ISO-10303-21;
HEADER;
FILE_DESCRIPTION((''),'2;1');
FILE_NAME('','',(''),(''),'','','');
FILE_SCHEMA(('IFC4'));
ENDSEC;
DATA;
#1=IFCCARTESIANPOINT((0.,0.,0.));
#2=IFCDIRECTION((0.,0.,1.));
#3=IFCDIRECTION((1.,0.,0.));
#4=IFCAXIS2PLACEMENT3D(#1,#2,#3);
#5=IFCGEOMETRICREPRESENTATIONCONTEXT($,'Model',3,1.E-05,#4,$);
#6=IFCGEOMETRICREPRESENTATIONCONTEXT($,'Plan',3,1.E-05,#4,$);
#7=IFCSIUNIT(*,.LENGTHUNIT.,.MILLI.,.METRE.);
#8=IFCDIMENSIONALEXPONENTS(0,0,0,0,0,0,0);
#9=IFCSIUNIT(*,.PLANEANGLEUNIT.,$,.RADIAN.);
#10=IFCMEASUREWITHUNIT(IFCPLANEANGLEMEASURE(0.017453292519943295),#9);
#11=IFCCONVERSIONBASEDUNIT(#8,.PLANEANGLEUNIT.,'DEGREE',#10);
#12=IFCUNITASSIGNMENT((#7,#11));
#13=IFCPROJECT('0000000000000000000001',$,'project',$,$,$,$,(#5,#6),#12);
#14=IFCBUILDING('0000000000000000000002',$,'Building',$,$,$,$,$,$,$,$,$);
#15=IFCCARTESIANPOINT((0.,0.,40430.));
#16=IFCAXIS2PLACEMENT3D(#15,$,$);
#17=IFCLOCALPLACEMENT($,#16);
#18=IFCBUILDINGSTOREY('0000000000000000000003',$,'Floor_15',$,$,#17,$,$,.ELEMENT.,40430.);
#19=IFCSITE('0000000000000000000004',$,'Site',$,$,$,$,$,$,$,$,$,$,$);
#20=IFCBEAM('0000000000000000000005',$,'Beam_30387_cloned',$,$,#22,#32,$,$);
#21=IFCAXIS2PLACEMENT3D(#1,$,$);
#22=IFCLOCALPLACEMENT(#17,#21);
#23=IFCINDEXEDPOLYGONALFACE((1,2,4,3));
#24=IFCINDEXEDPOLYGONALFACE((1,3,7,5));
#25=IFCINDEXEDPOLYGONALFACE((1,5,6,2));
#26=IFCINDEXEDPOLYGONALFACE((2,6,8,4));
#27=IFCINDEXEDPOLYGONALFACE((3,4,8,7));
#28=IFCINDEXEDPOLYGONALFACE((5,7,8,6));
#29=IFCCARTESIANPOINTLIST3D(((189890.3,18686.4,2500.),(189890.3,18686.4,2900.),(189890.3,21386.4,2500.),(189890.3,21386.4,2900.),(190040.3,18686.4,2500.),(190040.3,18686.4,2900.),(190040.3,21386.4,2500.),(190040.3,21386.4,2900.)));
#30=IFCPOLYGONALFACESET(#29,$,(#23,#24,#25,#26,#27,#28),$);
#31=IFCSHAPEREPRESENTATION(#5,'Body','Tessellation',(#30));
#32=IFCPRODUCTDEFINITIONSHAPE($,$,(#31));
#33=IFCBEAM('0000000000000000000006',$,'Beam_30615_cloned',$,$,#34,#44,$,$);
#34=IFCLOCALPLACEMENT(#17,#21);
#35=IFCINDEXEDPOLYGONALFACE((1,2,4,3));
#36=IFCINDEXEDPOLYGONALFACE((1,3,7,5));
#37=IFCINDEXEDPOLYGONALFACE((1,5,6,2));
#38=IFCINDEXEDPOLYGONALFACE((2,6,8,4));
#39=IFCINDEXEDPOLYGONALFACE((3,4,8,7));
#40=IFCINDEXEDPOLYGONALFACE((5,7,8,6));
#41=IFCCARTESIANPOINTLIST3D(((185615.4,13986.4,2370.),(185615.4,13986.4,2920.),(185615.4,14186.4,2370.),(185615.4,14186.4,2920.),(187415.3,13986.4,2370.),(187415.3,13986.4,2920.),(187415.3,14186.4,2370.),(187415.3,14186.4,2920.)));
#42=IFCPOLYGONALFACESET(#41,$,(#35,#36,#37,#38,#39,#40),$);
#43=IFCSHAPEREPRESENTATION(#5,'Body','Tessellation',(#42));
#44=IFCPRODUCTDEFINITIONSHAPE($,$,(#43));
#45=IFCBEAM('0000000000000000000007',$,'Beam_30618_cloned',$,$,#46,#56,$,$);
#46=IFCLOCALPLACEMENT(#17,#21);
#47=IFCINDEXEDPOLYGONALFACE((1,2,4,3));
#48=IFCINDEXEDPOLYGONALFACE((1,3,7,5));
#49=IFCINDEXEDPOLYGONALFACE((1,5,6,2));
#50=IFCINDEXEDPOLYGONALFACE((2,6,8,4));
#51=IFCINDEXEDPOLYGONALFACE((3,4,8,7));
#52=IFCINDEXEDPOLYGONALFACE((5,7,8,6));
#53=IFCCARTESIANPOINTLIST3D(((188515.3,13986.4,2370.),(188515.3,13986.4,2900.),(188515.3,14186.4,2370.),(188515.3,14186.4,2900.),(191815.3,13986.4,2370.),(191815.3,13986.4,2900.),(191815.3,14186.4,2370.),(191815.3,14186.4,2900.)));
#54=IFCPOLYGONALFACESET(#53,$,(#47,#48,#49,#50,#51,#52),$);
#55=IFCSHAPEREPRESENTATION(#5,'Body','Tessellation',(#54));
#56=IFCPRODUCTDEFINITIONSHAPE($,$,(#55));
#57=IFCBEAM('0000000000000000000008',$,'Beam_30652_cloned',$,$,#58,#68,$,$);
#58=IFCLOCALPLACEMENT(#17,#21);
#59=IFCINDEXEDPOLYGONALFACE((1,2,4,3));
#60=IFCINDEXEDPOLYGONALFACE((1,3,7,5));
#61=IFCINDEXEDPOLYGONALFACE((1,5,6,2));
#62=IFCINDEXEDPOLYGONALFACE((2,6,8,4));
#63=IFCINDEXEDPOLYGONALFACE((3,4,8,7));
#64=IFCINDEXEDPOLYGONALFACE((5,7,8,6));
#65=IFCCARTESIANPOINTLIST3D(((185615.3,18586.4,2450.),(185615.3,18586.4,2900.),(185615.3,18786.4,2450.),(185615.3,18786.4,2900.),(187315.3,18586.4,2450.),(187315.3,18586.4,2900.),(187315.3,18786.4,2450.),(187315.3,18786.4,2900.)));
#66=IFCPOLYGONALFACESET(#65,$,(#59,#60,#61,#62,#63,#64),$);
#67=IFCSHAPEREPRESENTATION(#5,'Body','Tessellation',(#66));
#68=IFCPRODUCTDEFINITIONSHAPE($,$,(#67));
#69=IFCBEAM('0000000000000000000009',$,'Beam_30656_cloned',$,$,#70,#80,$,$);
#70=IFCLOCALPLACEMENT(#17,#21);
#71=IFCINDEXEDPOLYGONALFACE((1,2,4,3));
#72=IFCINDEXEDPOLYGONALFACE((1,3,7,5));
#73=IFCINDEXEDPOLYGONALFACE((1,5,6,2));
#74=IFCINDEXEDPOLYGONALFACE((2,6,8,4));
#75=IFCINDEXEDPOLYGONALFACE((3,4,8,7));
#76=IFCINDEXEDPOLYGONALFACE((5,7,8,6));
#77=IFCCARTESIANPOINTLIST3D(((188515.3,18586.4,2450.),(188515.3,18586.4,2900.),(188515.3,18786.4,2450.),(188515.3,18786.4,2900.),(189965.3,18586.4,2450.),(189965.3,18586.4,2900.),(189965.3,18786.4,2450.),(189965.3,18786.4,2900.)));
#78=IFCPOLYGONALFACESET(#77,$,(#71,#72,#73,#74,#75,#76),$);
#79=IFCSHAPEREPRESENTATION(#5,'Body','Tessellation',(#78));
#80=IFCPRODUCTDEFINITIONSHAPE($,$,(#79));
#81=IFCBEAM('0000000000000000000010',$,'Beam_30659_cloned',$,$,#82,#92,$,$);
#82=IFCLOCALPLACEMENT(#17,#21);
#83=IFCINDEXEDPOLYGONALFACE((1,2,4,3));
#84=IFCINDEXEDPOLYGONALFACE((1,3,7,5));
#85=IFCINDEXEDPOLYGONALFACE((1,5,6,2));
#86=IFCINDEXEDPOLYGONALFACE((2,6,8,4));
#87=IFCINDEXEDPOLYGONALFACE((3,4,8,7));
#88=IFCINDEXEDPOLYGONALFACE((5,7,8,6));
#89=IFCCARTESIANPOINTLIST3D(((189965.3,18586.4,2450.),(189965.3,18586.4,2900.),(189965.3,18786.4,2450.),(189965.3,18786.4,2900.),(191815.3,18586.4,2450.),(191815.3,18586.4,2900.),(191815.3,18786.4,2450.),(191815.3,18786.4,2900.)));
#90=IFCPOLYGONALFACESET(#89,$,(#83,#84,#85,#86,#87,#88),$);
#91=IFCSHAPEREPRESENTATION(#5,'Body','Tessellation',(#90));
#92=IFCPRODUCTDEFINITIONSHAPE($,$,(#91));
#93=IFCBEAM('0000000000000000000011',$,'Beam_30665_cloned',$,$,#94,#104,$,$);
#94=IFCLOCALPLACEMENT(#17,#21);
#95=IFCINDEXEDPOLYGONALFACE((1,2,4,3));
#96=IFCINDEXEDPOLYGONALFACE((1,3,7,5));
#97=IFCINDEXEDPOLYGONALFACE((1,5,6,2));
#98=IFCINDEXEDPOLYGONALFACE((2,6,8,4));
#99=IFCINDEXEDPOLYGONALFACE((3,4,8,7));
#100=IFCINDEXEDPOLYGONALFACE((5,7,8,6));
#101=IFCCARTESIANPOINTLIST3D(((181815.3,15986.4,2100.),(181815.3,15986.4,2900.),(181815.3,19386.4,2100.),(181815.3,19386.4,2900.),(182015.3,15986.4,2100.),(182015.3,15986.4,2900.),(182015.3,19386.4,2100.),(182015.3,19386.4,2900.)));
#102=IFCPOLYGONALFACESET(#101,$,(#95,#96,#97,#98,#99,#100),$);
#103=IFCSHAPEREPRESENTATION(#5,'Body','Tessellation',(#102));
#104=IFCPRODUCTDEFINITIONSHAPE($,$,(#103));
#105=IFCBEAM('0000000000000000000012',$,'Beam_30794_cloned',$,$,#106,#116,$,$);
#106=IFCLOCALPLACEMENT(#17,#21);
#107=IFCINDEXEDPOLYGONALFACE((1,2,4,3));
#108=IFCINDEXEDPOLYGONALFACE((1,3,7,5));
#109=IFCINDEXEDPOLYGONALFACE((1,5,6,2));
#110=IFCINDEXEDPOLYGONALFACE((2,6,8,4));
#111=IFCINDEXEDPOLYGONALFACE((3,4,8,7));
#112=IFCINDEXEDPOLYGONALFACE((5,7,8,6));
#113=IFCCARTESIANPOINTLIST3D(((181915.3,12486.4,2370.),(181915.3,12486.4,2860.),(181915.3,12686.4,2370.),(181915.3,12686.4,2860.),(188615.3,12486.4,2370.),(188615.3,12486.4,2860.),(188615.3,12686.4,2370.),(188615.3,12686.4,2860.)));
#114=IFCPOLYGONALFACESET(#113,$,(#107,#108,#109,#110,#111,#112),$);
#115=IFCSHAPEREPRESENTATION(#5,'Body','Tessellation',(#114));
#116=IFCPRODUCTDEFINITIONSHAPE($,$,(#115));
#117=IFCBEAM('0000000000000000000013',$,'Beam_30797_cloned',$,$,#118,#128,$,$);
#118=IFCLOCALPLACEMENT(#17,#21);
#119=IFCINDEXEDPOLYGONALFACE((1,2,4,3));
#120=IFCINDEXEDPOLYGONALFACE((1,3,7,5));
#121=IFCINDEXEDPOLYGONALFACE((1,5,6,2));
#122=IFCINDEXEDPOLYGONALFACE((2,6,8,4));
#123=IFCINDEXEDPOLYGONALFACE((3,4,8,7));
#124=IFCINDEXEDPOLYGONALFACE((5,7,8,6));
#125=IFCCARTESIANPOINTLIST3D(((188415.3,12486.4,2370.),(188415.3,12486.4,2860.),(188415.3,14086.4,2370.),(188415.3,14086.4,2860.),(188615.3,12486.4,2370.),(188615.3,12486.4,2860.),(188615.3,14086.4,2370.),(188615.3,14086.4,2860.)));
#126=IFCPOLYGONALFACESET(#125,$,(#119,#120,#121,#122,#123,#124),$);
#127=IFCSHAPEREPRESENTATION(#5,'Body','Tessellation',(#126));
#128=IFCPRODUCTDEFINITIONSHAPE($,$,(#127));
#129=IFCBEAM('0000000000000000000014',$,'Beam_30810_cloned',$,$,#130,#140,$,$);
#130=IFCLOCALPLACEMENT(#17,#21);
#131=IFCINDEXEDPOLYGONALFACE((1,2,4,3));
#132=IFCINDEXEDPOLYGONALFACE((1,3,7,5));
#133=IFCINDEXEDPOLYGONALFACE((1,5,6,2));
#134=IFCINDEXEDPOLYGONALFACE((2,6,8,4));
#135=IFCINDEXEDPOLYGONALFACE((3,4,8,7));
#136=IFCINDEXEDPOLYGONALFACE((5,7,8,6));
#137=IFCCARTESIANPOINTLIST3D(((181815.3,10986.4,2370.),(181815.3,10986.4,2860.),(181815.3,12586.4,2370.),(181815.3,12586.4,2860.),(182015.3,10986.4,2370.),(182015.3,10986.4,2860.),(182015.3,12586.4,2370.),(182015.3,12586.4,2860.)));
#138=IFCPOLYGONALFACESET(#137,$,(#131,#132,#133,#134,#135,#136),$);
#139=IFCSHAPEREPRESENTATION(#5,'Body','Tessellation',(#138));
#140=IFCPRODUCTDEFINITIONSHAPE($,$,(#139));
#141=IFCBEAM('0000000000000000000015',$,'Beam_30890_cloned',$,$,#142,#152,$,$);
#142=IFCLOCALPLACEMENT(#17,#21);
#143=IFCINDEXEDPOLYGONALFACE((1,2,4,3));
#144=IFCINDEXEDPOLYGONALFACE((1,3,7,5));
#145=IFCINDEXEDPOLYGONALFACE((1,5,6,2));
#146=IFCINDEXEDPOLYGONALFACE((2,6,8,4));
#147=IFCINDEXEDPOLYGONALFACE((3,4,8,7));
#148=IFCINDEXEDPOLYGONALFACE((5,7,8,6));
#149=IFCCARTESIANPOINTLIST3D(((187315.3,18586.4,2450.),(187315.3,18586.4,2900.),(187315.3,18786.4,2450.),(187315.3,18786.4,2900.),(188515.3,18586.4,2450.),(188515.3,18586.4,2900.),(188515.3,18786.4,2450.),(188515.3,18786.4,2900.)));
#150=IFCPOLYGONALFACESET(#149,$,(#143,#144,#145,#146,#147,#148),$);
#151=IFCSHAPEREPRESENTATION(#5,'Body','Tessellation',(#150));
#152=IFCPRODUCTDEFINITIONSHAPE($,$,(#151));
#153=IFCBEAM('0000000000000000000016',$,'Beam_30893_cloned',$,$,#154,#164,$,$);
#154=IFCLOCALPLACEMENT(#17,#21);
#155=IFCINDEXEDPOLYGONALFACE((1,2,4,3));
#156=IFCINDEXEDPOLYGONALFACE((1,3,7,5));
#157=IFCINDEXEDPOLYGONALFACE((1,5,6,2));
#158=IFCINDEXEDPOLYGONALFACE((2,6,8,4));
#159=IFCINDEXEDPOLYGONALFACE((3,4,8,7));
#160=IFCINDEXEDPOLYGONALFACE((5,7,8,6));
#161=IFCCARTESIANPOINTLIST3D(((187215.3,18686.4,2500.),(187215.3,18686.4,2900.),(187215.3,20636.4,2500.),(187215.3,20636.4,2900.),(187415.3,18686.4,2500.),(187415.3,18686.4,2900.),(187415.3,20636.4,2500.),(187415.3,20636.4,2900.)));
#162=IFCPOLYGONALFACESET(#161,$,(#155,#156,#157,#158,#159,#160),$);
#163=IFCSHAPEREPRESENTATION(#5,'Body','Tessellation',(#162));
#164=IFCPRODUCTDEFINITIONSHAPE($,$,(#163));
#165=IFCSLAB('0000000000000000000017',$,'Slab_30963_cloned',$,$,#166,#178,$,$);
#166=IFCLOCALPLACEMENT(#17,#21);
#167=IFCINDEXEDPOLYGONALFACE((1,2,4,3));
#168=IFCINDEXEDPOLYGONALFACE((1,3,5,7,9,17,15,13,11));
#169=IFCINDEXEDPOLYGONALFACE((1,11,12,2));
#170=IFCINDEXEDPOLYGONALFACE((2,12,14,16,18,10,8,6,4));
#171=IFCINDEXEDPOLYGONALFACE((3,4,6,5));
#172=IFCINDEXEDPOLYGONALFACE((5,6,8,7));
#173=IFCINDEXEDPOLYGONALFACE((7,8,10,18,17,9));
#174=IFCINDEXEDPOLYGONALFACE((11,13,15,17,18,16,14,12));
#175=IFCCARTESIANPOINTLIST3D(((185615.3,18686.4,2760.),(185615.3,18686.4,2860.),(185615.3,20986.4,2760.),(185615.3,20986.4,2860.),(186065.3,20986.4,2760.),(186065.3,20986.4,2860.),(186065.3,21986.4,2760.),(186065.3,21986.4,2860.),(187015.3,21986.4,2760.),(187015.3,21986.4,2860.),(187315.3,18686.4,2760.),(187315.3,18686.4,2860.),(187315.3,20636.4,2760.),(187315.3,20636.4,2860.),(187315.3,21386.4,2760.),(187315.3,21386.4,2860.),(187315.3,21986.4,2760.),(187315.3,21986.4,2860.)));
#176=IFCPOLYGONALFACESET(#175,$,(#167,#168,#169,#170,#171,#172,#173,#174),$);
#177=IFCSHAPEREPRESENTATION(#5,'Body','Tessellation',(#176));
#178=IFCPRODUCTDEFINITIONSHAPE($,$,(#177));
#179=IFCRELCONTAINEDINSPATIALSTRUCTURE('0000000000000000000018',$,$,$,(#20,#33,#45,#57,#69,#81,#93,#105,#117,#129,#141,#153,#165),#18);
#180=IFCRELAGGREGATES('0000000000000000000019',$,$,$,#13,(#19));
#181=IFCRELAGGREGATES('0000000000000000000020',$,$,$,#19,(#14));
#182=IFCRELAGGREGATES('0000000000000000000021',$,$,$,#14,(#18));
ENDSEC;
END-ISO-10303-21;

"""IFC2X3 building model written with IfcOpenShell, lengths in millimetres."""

from ifc_helpers import new_model, entity, si_unit, converted_unit, frame, origin_with_axes, origin_2d, place, context, project, spatial, polyline, rectangle, outline, extrude, source, transform, mapped, element, save


model = new_model("IFC2X3")

# Units and contexts
model_context = context("Model", 3, precision=1e-05, world=origin_with_axes())
plan_context = context("Plan", 3, precision=1e-05, world=origin_with_axes())
ifc_project = project(units=[si_unit("LENGTHUNIT", "METRE", prefix="MILLI"), converted_unit("PLANEANGLEUNIT", "DEGREE", entity("IfcPlaneAngleMeasure", 0.017453292519943295), si_unit("PLANEANGLEUNIT", "RADIAN"), dimensions=[0, 0, 0, 0, 0, 0, 0])], contexts=[model_context, plan_context])

# Site, building, storey
site = spatial("IfcSite", under=ifc_project, Name="Site")
building = spatial("IfcBuilding", under=site, Name="Building")
storey_placement = place(None, frame((0.0, 0.0, 40430.0)))
storey = spatial("IfcBuildingStorey", under=building, at=storey_placement, Name="Floor_15", CompositionType="ELEMENT", Elevation=40430.0)

# Beams
shared_shape_1 = source(origin_with_axes(), model_context, "Body", "SweptSolid", [
    extrude(rectangle(XDim=150.0, YDim=400.0, at=origin_2d()), origin_with_axes(), (0.0, 0.0, 1.0), 2700.0),
])
beam_1_placement = place(storey_placement, frame((189965.3, 18686.4, 2700.0), z_axis=(0.0, 2700.0, 0.0), x_axis=(2700.0, 0.0, 0.0)))
element("IfcBeam", 1, at=beam_1_placement, inside=storey, Name="Beam_30387_cloned", context=model_context, shape_type="MappedRepresentation", body=[
    mapped(shared_shape_1, transform((0.0, 0.0, 0.0), x_axis=(1.0, 0.0, 0.0), y_axis=(0.0, 1.0, 0.0), z_axis=(0.0, 0.0, 1.0), scale=1.0)),
])
shared_shape_2 = source(origin_with_axes(), model_context, "Body", "SweptSolid", [
    extrude(rectangle(XDim=200.0, YDim=550.0, at=origin_2d()), origin_with_axes(), (0.0, 0.0, 1.0), 1799.9),
])
beam_2_placement = place(storey_placement, frame((185615.4, 14086.4, 2645.0), z_axis=(1799.945586, 0.0, 0.0), x_axis=(0.0, -1799.945586, 0.0)))
element("IfcBeam", 2, at=beam_2_placement, inside=storey, Name="Beam_30615_cloned", context=model_context, shape_type="MappedRepresentation", body=[
    mapped(shared_shape_2, transform((0.0, 0.0, 0.0), x_axis=(1.0, 0.0, 0.0), y_axis=(0.0, 1.0, 0.0), z_axis=(0.0, 0.0, 1.0), scale=1.0)),
])
shared_shape_3 = source(origin_with_axes(), model_context, "Body", "SweptSolid", [
    extrude(rectangle(XDim=200.0, YDim=530.0, at=origin_2d()), origin_with_axes(), (0.0, 0.0, 1.0), 3300.0),
])
beam_3_placement = place(storey_placement, frame((188515.3, 14086.4, 2635.0), z_axis=(3299.979202, 0.0, 0.0), x_axis=(0.0, -3299.979202, 0.0)))
element("IfcBeam", 3, at=beam_3_placement, inside=storey, Name="Beam_30618_cloned", context=model_context, shape_type="MappedRepresentation", body=[
    mapped(shared_shape_3, transform((0.0, 0.0, 0.0), x_axis=(1.0, 0.0, 0.0), y_axis=(0.0, 1.0, 0.0), z_axis=(0.0, 0.0, 1.0), scale=1.0)),
])
shared_shape_4 = source(origin_with_axes(), model_context, "Body", "SweptSolid", [
    extrude(rectangle(XDim=200.0, YDim=450.0, at=origin_2d()), origin_with_axes(), (0.0, 0.0, 1.0), 1700.0),
])
beam_4_placement = place(storey_placement, frame((185615.3, 18686.4, 2675.0), z_axis=(1700.0, 0.0, 0.0), x_axis=(0.0, -1700.0, 0.0)))
element("IfcBeam", 4, at=beam_4_placement, inside=storey, Name="Beam_30652_cloned", context=model_context, shape_type="MappedRepresentation", body=[
    mapped(shared_shape_4, transform((0.0, 0.0, 0.0), x_axis=(1.0, 0.0, 0.0), y_axis=(0.0, 1.0, 0.0), z_axis=(0.0, 0.0, 1.0), scale=1.0)),
])
shared_shape_5 = source(origin_with_axes(), model_context, "Body", "SweptSolid", [
    extrude(rectangle(XDim=200.0, YDim=450.0, at=origin_2d()), origin_with_axes(), (0.0, 0.0, 1.0), 1450.0),
])
beam_5_placement = place(storey_placement, frame((188515.3, 18686.4, 2675.0), z_axis=(1449.979201, 0.0, 0.0), x_axis=(0.0, -1449.979201, 0.0)))
element("IfcBeam", 5, at=beam_5_placement, inside=storey, Name="Beam_30656_cloned", context=model_context, shape_type="MappedRepresentation", body=[
    mapped(shared_shape_5, transform((0.0, 0.0, 0.0), x_axis=(1.0, 0.0, 0.0), y_axis=(0.0, 1.0, 0.0), z_axis=(0.0, 0.0, 1.0), scale=1.0)),
])
shared_shape_6 = source(origin_with_axes(), model_context, "Body", "SweptSolid", [
    extrude(rectangle(XDim=200.0, YDim=450.0, at=origin_2d()), origin_with_axes(), (0.0, 0.0, 1.0), 1850.0),
])
beam_6_placement = place(storey_placement, frame((189965.3, 18686.4, 2675.0), z_axis=(1850.0, 0.0, 0.0), x_axis=(0.0, -1850.0, 0.0)))
element("IfcBeam", 6, at=beam_6_placement, inside=storey, Name="Beam_30659_cloned", context=model_context, shape_type="MappedRepresentation", body=[
    mapped(shared_shape_6, transform((0.0, 0.0, 0.0), x_axis=(1.0, 0.0, 0.0), y_axis=(0.0, 1.0, 0.0), z_axis=(0.0, 0.0, 1.0), scale=1.0)),
])
shared_shape_7 = source(origin_with_axes(), model_context, "Body", "SweptSolid", [
    extrude(rectangle(XDim=200.0, YDim=800.0, at=origin_2d()), origin_with_axes(), (0.0, 0.0, 1.0), 3400.0),
])
beam_7_placement = place(storey_placement, frame((181915.3, 15986.4, 2500.0), z_axis=(0.0, 3400.000002, 0.0), x_axis=(3400.000002, 0.0, 0.0)))
element("IfcBeam", 7, at=beam_7_placement, inside=storey, Name="Beam_30665_cloned", context=model_context, shape_type="MappedRepresentation", body=[
    mapped(shared_shape_7, transform((0.0, 0.0, 0.0), x_axis=(1.0, 0.0, 0.0), y_axis=(0.0, 1.0, 0.0), z_axis=(0.0, 0.0, 1.0), scale=1.0)),
])
shared_shape_8 = source(origin_with_axes(), model_context, "Body", "SweptSolid", [
    extrude(rectangle(XDim=200.0, YDim=490.0, at=origin_2d()), origin_with_axes(), (0.0, 0.0, 1.0), 6700.0),
])
beam_8_placement = place(storey_placement, frame((181915.3, 12586.4, 2615.0), z_axis=(6700.020798, 0.0, 0.0), x_axis=(0.0, -6700.020798, 0.0)))
element("IfcBeam", 8, at=beam_8_placement, inside=storey, Name="Beam_30794_cloned", context=model_context, shape_type="MappedRepresentation", body=[
    mapped(shared_shape_8, transform((0.0, 0.0, 0.0), x_axis=(1.0, 0.0, 0.0), y_axis=(0.0, 1.0, 0.0), z_axis=(0.0, 0.0, 1.0), scale=1.0)),
])
shared_shape_9 = source(origin_with_axes(), model_context, "Body", "SweptSolid", [
    extrude(rectangle(XDim=200.0, YDim=490.0, at=origin_2d()), origin_with_axes(), (0.0, 0.0, 1.0), 1600.0),
])
beam_9_placement = place(storey_placement, frame((188515.3, 12486.4, 2615.0), z_axis=(0.0, 1600.000004, 0.0), x_axis=(1600.000004, 0.0, 0.0)))
element("IfcBeam", 9, at=beam_9_placement, inside=storey, Name="Beam_30797_cloned", context=model_context, shape_type="MappedRepresentation", body=[
    mapped(shared_shape_9, transform((0.0, 0.0, 0.0), x_axis=(1.0, 0.0, 0.0), y_axis=(0.0, 1.0, 0.0), z_axis=(0.0, 0.0, 1.0), scale=1.0)),
])
shared_shape_10 = source(origin_with_axes(), model_context, "Body", "SweptSolid", [
    extrude(rectangle(XDim=200.0, YDim=490.0, at=origin_2d()), origin_with_axes(), (0.0, 0.0, 1.0), 1600.0),
])
beam_10_placement = place(storey_placement, frame((181915.3, 10986.4, 2615.0), z_axis=(0.0, 1600.0, 0.0), x_axis=(1600.0, 0.0, 0.0)))
element("IfcBeam", 10, at=beam_10_placement, inside=storey, Name="Beam_30810_cloned", context=model_context, shape_type="MappedRepresentation", body=[
    mapped(shared_shape_10, transform((0.0, 0.0, 0.0), x_axis=(1.0, 0.0, 0.0), y_axis=(0.0, 1.0, 0.0), z_axis=(0.0, 0.0, 1.0), scale=1.0)),
])
shared_shape_11 = source(origin_with_axes(), model_context, "Body", "SweptSolid", [
    extrude(rectangle(XDim=200.0, YDim=450.0, at=origin_2d()), origin_with_axes(), (0.0, 0.0, 1.0), 1200.0),
])
beam_11_placement = place(storey_placement, frame((187315.3, 18686.4, 2675.0), z_axis=(1200.020799, 0.0, 0.0), x_axis=(0.0, -1200.020799, 0.0)))
element("IfcBeam", 11, at=beam_11_placement, inside=storey, Name="Beam_30890_cloned", context=model_context, shape_type="MappedRepresentation", body=[
    mapped(shared_shape_11, transform((0.0, 0.0, 0.0), x_axis=(1.0, 0.0, 0.0), y_axis=(0.0, 1.0, 0.0), z_axis=(0.0, 0.0, 1.0), scale=1.0)),
])
shared_shape_12 = source(origin_with_axes(), model_context, "Body", "SweptSolid", [
    extrude(rectangle(XDim=200.0, YDim=400.0, at=origin_2d()), origin_with_axes(), (0.0, 0.0, 1.0), 1950.0),
])
beam_12_placement = place(storey_placement, frame((187315.3, 18686.4, 2700.0), z_axis=(0.0, 1950.0, 0.0), x_axis=(1950.0, 0.0, 0.0)))
element("IfcBeam", 12, at=beam_12_placement, inside=storey, Name="Beam_30893_cloned", context=model_context, shape_type="MappedRepresentation", body=[
    mapped(shared_shape_12, transform((0.0, 0.0, 0.0), x_axis=(1.0, 0.0, 0.0), y_axis=(0.0, 1.0, 0.0), z_axis=(0.0, 0.0, 1.0), scale=1.0)),
])

# Slab
shared_shape_13 = source(origin_with_axes(), model_context, "Body", "SweptSolid", [
    extrude(outline(polyline([(0.0, 0.0), (1700.0, 0.0), (1700.0, 1950.0), (1700.0, 2700.0), (1700.0, 3300.0), (1400.0, 3300.0), (450.0, 3300.0), (450.0, 2300.0), (0.0, 2300.0)])), origin_with_axes(), (0.0, 0.0, 1.0), 100.0),
])
slab_1_placement = place(storey_placement, frame((185615.3, 18686.4, 2760.0), z_axis=(0.0, 0.0, 1.0), x_axis=(1700.0, 0.0, 0.0)))
element("IfcSlab", 13, at=slab_1_placement, inside=storey, Name="Slab_30963_cloned", context=model_context, shape_type="MappedRepresentation", body=[
    mapped(shared_shape_13, transform((0.0, 0.0, 0.0), x_axis=(1.0, 0.0, 0.0), y_axis=(0.0, 1.0, 0.0), z_axis=(0.0, 0.0, 1.0), scale=1.0)),
])

save(model, "model.ifc")
